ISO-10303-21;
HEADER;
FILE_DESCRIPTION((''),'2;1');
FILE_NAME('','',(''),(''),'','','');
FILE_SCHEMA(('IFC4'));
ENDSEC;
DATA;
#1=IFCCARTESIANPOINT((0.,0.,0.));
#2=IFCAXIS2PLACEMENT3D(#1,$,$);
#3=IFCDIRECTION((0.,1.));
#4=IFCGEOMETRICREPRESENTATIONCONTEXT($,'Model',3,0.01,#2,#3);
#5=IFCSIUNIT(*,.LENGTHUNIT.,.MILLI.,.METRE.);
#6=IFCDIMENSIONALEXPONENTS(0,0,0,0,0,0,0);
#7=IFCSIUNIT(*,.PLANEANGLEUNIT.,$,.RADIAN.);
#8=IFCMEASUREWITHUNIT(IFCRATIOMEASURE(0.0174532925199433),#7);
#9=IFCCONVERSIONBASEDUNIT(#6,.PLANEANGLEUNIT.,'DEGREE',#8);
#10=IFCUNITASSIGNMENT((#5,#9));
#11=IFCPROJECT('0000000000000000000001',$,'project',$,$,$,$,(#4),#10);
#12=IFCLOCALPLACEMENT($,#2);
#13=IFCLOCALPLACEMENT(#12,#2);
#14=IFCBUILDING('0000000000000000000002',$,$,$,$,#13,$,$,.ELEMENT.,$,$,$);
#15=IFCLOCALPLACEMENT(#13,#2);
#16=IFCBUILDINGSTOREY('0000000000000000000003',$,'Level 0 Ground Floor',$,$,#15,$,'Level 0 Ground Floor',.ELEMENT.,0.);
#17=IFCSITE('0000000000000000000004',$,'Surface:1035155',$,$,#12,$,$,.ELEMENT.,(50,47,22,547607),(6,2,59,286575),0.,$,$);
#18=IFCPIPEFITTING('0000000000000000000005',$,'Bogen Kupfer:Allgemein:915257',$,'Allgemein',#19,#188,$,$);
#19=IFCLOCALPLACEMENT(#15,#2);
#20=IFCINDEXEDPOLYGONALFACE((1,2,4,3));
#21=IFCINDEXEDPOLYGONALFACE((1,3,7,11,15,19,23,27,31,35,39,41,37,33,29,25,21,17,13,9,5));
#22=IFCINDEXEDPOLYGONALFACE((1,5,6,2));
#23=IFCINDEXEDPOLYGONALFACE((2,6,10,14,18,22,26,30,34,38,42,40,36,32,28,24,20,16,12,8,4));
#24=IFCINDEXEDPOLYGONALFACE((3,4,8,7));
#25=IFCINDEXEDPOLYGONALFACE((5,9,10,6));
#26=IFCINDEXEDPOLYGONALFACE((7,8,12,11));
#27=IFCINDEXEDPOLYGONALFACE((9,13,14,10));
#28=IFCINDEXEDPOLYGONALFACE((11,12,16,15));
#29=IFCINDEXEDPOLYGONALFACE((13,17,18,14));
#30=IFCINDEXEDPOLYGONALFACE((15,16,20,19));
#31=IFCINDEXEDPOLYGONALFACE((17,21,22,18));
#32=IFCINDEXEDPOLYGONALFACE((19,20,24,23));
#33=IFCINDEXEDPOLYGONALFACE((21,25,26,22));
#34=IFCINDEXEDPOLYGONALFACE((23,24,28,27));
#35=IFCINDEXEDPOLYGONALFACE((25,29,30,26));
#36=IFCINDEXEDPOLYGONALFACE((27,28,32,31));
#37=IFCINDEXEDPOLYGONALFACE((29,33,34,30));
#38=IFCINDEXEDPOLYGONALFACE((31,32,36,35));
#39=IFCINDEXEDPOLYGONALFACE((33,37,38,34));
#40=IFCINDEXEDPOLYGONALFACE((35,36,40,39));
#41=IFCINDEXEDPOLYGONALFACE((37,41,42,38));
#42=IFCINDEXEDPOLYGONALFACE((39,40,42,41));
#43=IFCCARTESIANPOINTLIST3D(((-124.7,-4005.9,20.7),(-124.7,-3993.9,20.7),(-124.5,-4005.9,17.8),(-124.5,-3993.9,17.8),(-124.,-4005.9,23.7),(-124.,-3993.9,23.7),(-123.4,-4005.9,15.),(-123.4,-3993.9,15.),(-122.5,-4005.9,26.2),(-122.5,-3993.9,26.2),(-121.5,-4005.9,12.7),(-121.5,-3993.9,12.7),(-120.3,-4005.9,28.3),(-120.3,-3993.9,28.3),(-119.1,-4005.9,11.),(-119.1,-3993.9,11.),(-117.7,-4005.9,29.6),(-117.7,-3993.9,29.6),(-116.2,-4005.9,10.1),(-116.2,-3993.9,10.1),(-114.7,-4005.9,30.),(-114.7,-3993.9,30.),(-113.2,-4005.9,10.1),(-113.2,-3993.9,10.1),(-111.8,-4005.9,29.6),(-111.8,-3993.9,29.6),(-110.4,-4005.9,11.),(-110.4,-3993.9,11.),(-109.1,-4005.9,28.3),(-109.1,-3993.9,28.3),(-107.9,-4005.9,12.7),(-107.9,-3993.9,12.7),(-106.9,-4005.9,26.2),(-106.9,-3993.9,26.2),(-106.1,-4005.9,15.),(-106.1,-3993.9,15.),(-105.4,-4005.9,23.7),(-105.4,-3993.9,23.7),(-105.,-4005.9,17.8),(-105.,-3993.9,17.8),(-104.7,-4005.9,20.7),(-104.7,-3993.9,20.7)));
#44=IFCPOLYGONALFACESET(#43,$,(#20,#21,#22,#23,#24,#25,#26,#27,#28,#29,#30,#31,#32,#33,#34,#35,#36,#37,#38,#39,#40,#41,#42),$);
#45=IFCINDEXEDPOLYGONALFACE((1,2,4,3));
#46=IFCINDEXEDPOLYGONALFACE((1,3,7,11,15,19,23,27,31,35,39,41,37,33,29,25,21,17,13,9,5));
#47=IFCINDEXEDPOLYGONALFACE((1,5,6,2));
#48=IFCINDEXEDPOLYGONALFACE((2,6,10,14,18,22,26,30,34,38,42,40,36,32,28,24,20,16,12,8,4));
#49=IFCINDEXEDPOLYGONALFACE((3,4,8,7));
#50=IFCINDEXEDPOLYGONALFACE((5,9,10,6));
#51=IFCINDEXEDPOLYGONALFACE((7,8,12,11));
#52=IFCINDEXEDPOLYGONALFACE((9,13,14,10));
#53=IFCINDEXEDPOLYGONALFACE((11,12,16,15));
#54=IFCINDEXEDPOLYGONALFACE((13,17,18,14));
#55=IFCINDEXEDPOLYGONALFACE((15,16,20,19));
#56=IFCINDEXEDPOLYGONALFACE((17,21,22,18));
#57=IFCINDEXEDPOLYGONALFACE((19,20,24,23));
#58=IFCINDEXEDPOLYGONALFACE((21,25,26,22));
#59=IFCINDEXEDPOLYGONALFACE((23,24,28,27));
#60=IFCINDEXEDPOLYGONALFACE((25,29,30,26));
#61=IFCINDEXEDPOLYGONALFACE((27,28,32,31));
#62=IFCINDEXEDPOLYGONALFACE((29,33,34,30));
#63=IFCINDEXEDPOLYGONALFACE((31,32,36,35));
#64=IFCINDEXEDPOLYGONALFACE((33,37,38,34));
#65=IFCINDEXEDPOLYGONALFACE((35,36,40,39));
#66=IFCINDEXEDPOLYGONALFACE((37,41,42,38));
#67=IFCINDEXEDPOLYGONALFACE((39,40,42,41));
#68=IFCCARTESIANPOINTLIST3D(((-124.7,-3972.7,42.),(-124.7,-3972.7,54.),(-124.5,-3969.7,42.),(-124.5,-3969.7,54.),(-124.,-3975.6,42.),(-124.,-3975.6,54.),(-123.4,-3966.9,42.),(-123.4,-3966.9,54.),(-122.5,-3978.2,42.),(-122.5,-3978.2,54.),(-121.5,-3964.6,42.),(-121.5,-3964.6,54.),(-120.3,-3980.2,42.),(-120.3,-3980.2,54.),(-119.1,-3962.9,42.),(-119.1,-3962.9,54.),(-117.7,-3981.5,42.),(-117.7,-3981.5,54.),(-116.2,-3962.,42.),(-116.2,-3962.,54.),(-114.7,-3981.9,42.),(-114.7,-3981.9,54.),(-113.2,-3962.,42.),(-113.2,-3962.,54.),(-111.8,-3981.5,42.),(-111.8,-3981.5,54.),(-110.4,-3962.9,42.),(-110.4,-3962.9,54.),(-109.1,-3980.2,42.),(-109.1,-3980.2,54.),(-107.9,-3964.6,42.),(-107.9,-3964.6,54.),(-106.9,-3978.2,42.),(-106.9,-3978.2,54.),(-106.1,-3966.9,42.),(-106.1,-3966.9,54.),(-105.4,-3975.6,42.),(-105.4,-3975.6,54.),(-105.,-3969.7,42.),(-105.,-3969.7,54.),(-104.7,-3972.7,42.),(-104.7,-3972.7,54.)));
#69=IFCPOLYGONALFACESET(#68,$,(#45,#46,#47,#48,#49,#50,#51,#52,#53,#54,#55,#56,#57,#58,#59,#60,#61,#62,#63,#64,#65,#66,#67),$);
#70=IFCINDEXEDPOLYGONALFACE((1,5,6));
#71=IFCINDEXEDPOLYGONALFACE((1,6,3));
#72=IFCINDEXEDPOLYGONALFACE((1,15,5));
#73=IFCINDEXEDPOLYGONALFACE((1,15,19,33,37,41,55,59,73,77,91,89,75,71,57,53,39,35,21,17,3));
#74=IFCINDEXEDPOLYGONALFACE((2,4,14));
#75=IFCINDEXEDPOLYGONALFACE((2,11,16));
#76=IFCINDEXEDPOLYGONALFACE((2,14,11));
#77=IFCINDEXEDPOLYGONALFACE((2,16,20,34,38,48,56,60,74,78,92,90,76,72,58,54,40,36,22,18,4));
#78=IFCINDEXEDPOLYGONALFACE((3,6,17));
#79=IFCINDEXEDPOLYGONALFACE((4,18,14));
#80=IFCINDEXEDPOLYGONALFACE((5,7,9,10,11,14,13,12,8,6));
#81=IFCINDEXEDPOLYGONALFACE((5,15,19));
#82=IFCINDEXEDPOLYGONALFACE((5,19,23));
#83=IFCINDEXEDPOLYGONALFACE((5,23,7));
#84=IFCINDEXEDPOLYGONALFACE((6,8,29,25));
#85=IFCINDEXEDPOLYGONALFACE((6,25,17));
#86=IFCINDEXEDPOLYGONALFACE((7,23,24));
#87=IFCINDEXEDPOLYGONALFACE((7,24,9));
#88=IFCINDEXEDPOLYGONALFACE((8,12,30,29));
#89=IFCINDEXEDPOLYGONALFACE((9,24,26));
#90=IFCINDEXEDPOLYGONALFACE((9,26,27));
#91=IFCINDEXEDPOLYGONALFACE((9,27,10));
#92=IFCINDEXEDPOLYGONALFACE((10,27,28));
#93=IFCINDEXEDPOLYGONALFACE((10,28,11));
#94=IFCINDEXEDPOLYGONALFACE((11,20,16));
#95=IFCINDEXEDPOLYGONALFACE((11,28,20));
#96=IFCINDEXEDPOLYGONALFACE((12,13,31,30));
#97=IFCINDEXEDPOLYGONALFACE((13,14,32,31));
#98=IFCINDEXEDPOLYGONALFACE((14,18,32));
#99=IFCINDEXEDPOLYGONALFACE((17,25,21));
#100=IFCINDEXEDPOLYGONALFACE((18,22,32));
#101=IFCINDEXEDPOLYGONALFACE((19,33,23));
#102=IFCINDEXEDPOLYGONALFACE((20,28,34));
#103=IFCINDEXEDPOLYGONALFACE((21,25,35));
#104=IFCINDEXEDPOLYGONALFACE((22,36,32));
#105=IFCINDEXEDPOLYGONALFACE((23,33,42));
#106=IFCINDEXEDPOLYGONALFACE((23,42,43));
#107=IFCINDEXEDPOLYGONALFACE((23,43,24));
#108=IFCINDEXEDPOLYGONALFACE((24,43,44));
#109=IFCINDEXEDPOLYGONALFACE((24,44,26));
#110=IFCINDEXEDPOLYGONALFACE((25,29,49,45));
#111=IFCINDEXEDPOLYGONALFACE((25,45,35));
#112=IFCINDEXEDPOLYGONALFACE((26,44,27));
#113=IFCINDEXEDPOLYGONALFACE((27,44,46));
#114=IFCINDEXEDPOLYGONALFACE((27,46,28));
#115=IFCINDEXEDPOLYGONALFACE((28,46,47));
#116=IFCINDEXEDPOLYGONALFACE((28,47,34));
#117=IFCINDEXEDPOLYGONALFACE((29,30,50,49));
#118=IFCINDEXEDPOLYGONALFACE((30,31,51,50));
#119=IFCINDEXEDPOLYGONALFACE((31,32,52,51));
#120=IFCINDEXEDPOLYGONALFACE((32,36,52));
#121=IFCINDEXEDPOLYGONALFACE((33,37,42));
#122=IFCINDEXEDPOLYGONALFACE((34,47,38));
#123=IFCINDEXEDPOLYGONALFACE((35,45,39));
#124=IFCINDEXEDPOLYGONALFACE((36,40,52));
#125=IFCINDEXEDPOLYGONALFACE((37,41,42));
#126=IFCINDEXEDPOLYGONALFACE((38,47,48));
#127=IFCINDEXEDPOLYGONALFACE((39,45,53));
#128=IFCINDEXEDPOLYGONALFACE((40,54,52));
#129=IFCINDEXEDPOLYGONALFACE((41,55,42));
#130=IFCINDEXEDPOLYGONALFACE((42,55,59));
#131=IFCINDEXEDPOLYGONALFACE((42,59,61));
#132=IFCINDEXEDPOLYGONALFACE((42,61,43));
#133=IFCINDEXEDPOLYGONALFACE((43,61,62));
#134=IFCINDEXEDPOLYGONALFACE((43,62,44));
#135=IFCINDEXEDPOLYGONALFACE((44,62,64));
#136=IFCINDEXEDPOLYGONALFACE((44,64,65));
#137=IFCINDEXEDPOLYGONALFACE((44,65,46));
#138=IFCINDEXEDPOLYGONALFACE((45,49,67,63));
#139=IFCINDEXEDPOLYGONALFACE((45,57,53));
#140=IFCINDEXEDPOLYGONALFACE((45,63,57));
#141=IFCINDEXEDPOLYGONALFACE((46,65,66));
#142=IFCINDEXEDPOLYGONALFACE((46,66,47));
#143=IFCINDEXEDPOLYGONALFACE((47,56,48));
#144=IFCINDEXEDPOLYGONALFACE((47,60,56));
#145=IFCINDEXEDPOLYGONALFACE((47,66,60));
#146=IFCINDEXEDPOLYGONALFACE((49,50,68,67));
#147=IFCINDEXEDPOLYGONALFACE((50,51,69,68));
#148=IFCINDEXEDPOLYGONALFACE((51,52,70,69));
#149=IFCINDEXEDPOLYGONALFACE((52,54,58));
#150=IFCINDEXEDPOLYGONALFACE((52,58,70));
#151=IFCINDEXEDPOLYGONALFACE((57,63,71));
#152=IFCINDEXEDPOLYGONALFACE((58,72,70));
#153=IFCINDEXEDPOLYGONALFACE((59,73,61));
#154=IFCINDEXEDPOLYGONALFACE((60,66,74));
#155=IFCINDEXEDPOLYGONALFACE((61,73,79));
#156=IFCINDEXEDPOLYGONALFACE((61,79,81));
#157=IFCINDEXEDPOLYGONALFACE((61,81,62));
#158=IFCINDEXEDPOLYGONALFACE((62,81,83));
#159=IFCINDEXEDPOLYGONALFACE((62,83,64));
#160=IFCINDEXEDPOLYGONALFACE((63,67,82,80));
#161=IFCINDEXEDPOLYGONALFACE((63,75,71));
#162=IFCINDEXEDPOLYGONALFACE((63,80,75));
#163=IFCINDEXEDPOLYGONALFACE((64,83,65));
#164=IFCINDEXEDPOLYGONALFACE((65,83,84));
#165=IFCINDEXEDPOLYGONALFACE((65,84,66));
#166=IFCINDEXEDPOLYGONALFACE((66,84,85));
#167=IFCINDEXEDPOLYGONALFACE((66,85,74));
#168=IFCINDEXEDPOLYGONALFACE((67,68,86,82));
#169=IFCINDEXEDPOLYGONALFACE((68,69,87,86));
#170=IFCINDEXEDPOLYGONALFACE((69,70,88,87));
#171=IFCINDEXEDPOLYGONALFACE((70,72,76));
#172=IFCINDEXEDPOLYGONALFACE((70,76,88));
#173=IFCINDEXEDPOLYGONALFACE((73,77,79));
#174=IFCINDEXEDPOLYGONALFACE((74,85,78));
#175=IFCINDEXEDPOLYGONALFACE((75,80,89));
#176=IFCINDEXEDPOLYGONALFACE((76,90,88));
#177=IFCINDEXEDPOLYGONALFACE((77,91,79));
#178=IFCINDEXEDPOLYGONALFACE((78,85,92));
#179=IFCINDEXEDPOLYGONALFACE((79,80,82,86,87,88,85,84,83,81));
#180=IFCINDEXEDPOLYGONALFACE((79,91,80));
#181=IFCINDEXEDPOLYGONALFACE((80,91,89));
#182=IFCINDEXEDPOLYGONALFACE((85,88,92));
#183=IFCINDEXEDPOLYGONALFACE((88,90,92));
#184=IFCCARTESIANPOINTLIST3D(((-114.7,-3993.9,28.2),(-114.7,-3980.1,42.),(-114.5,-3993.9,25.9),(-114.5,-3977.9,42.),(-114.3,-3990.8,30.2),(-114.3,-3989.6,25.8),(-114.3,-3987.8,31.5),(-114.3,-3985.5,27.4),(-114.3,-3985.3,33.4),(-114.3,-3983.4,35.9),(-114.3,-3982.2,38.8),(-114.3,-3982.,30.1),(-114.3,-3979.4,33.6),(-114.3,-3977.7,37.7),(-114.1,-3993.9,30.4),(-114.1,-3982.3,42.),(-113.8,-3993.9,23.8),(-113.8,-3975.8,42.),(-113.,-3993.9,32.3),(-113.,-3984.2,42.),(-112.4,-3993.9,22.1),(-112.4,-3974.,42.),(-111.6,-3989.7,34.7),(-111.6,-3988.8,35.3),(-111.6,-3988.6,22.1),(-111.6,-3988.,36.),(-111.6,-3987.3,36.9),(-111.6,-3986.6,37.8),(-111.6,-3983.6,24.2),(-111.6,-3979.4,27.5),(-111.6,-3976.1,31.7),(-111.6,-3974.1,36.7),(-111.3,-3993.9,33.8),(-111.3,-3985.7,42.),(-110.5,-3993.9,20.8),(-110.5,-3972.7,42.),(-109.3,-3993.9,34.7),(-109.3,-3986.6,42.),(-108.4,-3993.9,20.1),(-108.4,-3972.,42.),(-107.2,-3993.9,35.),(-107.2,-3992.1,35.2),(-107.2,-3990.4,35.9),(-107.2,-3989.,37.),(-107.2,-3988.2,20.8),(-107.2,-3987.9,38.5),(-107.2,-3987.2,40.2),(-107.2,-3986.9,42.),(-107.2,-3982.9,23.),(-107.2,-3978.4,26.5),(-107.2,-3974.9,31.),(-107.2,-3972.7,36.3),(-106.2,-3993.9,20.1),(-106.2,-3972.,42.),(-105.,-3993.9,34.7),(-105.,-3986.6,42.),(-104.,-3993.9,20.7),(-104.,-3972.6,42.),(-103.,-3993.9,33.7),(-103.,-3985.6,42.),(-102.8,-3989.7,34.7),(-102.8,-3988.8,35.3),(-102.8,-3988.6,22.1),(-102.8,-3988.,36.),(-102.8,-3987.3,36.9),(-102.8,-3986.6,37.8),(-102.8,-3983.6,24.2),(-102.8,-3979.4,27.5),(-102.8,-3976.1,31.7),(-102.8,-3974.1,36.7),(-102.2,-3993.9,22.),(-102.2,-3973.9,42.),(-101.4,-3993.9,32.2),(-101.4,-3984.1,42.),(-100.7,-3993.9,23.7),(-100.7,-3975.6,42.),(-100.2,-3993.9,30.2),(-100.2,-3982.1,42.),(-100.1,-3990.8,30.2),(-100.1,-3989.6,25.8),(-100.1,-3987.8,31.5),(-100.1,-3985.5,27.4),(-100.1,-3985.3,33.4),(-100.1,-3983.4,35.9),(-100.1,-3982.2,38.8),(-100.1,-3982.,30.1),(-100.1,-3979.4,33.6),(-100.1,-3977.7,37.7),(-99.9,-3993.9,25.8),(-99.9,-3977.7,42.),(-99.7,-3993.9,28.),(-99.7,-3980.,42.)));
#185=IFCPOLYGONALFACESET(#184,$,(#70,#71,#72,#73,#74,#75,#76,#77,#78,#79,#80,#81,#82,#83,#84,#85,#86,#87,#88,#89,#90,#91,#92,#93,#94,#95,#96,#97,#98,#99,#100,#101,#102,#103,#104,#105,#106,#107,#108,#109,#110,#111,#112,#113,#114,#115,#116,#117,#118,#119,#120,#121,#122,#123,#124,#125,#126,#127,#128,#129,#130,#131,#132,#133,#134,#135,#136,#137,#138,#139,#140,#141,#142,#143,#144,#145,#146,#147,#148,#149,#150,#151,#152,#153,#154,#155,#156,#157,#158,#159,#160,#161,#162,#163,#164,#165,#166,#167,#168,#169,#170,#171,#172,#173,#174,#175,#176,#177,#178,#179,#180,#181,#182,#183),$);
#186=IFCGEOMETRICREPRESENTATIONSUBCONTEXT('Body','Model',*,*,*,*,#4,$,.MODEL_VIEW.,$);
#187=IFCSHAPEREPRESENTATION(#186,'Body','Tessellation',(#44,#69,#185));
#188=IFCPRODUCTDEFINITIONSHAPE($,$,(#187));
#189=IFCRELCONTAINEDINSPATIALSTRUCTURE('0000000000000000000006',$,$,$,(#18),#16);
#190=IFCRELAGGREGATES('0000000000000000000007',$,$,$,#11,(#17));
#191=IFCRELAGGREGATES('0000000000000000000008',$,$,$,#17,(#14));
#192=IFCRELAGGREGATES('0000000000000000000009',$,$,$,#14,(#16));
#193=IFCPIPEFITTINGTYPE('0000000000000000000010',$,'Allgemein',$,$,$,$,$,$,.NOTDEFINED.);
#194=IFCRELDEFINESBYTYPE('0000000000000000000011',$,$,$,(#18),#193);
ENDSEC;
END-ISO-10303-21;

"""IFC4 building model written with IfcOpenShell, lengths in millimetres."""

from ifc_helpers import new_model, entity, si_unit, converted_unit, direction, frame, frame_2d, origin, place, context, subcontext, project, spatial, circle, extrude, source, transform, mapped, type_object, type_shapes, element, save


model = new_model("IFC4")

# Units and contexts
model_context = context("Model", 3, precision=0.01, world=origin(), true_north=direction((0.0, 1.0)))
body_context = subcontext(model_context, "Body", "Model", "MODEL_VIEW")
ifc_project = project(units=[si_unit("LENGTHUNIT", "METRE", prefix="MILLI"), converted_unit("PLANEANGLEUNIT", "DEGREE", entity("IfcRatioMeasure", 0.0174532925199433), si_unit("PLANEANGLEUNIT", "RADIAN"), dimensions=[0, 0, 0, 0, 0, 0, 0])], contexts=[model_context])

# Site, building, storey
site_placement = place(None, origin())
site = spatial("IfcSite", under=ifc_project, at=site_placement, Name="Surface:1035155", CompositionType="ELEMENT", RefLatitude=(50, 47, 22, 547607), RefLongitude=(6, 2, 59, 286575), RefElevation=0.0)
building_placement = place(site_placement, origin())
building = spatial("IfcBuilding", under=site, at=building_placement, CompositionType="ELEMENT")
storey_placement = place(building_placement, origin())
storey = spatial("IfcBuildingStorey", under=building, at=storey_placement, Name="Level 0 Ground Floor", LongName="Level 0 Ground Floor", CompositionType="ELEMENT", Elevation=0.0)

# Shared definitions
pipe_fitting_type = type_object("IfcPipeFittingType", Name="Allgemein", PredefinedType="NOTDEFINED")
ifc_direction = entity("IfcDirection", [0.0, 0.0, -1.0])
trimmed_curve = entity("IfcTrimmedCurve", entity("IfcCircle", entity("IfcAxis2Placement2D", entity("IfcCartesianPoint", [-14.5, 0.0]), entity("IfcDirection", [0.0, 1.0])), 14.5), [entity("IfcParameterValue", 270.0)], [entity("IfcParameterValue", 0.0)], True, "PARAMETER")
shared_shape_1 = source(origin(), body_context, "Body", "SolidModel", [
    extrude(circle(Radius=10.0, at=frame_2d((0.0, 0.0), x_axis=(1.0, 0.0))), frame((0.0, 22.0, 0.0), z_axis=(0.0, 1.0, 0.0), x_axis=(-1.0, 0.0, 0.0)), (0.0, 0.0, 1.0), 12.0),
    extrude(circle(Radius=10.0, at=frame_2d((0.0, 0.0), x_axis=(1.0, 0.0))), frame((-34.0, 0.0, 0.0), z_axis=(1.0, 0.0, 0.0), x_axis=(0.0, 1.0, 0.0)), (0.0, 0.0, 1.0), 12.0),
    entity("IfcSurfaceCurveSweptAreaSolid", entity("IfcCircleProfileDef", "AREA", None, entity("IfcAxis2Placement2D", entity("IfcCartesianPoint", [0.0, 7.5]), entity("IfcDirection", [1.0, 0.0])), 7.5), entity("IfcAxis2Placement3D", entity("IfcCartesianPoint", [-7.5, 22.0, 0.0]), ifc_direction, entity("IfcDirection", [1.0, 0.0, 0.0])), trimmed_curve, 0.0, 90.0, entity("IfcSurfaceOfLinearExtrusion", entity("IfcArbitraryOpenProfileDef", "CURVE", None, trimmed_curve), entity("IfcAxis2Placement3D", entity("IfcCartesianPoint", [0.0, 0.0, -304.8])), ifc_direction, 1.0)),
])
type_shapes(pipe_fitting_type, [shared_shape_1])

# Pipe fitting
for number, where, z_axis, x_axis, name in (
    (1, (-114.7, -3971.9, 20.0), (-1.0, 0.0, 0.0), (0.0, 0.0, -1.0), "Bogen Kupfer:Allgemein:915257"),
):
    element("IfcPipeFitting", number, at=place(storey_placement, frame(where, z_axis=z_axis, x_axis=x_axis)), inside=storey, type_object=pipe_fitting_type, Name=name, ObjectType="Allgemein", context=body_context, shape_type="MappedRepresentation", body=[
        mapped(shared_shape_1, transform((0.0, 0.0, 0.0), scale=1.0)),
    ])

save(model, "model.ifc")
